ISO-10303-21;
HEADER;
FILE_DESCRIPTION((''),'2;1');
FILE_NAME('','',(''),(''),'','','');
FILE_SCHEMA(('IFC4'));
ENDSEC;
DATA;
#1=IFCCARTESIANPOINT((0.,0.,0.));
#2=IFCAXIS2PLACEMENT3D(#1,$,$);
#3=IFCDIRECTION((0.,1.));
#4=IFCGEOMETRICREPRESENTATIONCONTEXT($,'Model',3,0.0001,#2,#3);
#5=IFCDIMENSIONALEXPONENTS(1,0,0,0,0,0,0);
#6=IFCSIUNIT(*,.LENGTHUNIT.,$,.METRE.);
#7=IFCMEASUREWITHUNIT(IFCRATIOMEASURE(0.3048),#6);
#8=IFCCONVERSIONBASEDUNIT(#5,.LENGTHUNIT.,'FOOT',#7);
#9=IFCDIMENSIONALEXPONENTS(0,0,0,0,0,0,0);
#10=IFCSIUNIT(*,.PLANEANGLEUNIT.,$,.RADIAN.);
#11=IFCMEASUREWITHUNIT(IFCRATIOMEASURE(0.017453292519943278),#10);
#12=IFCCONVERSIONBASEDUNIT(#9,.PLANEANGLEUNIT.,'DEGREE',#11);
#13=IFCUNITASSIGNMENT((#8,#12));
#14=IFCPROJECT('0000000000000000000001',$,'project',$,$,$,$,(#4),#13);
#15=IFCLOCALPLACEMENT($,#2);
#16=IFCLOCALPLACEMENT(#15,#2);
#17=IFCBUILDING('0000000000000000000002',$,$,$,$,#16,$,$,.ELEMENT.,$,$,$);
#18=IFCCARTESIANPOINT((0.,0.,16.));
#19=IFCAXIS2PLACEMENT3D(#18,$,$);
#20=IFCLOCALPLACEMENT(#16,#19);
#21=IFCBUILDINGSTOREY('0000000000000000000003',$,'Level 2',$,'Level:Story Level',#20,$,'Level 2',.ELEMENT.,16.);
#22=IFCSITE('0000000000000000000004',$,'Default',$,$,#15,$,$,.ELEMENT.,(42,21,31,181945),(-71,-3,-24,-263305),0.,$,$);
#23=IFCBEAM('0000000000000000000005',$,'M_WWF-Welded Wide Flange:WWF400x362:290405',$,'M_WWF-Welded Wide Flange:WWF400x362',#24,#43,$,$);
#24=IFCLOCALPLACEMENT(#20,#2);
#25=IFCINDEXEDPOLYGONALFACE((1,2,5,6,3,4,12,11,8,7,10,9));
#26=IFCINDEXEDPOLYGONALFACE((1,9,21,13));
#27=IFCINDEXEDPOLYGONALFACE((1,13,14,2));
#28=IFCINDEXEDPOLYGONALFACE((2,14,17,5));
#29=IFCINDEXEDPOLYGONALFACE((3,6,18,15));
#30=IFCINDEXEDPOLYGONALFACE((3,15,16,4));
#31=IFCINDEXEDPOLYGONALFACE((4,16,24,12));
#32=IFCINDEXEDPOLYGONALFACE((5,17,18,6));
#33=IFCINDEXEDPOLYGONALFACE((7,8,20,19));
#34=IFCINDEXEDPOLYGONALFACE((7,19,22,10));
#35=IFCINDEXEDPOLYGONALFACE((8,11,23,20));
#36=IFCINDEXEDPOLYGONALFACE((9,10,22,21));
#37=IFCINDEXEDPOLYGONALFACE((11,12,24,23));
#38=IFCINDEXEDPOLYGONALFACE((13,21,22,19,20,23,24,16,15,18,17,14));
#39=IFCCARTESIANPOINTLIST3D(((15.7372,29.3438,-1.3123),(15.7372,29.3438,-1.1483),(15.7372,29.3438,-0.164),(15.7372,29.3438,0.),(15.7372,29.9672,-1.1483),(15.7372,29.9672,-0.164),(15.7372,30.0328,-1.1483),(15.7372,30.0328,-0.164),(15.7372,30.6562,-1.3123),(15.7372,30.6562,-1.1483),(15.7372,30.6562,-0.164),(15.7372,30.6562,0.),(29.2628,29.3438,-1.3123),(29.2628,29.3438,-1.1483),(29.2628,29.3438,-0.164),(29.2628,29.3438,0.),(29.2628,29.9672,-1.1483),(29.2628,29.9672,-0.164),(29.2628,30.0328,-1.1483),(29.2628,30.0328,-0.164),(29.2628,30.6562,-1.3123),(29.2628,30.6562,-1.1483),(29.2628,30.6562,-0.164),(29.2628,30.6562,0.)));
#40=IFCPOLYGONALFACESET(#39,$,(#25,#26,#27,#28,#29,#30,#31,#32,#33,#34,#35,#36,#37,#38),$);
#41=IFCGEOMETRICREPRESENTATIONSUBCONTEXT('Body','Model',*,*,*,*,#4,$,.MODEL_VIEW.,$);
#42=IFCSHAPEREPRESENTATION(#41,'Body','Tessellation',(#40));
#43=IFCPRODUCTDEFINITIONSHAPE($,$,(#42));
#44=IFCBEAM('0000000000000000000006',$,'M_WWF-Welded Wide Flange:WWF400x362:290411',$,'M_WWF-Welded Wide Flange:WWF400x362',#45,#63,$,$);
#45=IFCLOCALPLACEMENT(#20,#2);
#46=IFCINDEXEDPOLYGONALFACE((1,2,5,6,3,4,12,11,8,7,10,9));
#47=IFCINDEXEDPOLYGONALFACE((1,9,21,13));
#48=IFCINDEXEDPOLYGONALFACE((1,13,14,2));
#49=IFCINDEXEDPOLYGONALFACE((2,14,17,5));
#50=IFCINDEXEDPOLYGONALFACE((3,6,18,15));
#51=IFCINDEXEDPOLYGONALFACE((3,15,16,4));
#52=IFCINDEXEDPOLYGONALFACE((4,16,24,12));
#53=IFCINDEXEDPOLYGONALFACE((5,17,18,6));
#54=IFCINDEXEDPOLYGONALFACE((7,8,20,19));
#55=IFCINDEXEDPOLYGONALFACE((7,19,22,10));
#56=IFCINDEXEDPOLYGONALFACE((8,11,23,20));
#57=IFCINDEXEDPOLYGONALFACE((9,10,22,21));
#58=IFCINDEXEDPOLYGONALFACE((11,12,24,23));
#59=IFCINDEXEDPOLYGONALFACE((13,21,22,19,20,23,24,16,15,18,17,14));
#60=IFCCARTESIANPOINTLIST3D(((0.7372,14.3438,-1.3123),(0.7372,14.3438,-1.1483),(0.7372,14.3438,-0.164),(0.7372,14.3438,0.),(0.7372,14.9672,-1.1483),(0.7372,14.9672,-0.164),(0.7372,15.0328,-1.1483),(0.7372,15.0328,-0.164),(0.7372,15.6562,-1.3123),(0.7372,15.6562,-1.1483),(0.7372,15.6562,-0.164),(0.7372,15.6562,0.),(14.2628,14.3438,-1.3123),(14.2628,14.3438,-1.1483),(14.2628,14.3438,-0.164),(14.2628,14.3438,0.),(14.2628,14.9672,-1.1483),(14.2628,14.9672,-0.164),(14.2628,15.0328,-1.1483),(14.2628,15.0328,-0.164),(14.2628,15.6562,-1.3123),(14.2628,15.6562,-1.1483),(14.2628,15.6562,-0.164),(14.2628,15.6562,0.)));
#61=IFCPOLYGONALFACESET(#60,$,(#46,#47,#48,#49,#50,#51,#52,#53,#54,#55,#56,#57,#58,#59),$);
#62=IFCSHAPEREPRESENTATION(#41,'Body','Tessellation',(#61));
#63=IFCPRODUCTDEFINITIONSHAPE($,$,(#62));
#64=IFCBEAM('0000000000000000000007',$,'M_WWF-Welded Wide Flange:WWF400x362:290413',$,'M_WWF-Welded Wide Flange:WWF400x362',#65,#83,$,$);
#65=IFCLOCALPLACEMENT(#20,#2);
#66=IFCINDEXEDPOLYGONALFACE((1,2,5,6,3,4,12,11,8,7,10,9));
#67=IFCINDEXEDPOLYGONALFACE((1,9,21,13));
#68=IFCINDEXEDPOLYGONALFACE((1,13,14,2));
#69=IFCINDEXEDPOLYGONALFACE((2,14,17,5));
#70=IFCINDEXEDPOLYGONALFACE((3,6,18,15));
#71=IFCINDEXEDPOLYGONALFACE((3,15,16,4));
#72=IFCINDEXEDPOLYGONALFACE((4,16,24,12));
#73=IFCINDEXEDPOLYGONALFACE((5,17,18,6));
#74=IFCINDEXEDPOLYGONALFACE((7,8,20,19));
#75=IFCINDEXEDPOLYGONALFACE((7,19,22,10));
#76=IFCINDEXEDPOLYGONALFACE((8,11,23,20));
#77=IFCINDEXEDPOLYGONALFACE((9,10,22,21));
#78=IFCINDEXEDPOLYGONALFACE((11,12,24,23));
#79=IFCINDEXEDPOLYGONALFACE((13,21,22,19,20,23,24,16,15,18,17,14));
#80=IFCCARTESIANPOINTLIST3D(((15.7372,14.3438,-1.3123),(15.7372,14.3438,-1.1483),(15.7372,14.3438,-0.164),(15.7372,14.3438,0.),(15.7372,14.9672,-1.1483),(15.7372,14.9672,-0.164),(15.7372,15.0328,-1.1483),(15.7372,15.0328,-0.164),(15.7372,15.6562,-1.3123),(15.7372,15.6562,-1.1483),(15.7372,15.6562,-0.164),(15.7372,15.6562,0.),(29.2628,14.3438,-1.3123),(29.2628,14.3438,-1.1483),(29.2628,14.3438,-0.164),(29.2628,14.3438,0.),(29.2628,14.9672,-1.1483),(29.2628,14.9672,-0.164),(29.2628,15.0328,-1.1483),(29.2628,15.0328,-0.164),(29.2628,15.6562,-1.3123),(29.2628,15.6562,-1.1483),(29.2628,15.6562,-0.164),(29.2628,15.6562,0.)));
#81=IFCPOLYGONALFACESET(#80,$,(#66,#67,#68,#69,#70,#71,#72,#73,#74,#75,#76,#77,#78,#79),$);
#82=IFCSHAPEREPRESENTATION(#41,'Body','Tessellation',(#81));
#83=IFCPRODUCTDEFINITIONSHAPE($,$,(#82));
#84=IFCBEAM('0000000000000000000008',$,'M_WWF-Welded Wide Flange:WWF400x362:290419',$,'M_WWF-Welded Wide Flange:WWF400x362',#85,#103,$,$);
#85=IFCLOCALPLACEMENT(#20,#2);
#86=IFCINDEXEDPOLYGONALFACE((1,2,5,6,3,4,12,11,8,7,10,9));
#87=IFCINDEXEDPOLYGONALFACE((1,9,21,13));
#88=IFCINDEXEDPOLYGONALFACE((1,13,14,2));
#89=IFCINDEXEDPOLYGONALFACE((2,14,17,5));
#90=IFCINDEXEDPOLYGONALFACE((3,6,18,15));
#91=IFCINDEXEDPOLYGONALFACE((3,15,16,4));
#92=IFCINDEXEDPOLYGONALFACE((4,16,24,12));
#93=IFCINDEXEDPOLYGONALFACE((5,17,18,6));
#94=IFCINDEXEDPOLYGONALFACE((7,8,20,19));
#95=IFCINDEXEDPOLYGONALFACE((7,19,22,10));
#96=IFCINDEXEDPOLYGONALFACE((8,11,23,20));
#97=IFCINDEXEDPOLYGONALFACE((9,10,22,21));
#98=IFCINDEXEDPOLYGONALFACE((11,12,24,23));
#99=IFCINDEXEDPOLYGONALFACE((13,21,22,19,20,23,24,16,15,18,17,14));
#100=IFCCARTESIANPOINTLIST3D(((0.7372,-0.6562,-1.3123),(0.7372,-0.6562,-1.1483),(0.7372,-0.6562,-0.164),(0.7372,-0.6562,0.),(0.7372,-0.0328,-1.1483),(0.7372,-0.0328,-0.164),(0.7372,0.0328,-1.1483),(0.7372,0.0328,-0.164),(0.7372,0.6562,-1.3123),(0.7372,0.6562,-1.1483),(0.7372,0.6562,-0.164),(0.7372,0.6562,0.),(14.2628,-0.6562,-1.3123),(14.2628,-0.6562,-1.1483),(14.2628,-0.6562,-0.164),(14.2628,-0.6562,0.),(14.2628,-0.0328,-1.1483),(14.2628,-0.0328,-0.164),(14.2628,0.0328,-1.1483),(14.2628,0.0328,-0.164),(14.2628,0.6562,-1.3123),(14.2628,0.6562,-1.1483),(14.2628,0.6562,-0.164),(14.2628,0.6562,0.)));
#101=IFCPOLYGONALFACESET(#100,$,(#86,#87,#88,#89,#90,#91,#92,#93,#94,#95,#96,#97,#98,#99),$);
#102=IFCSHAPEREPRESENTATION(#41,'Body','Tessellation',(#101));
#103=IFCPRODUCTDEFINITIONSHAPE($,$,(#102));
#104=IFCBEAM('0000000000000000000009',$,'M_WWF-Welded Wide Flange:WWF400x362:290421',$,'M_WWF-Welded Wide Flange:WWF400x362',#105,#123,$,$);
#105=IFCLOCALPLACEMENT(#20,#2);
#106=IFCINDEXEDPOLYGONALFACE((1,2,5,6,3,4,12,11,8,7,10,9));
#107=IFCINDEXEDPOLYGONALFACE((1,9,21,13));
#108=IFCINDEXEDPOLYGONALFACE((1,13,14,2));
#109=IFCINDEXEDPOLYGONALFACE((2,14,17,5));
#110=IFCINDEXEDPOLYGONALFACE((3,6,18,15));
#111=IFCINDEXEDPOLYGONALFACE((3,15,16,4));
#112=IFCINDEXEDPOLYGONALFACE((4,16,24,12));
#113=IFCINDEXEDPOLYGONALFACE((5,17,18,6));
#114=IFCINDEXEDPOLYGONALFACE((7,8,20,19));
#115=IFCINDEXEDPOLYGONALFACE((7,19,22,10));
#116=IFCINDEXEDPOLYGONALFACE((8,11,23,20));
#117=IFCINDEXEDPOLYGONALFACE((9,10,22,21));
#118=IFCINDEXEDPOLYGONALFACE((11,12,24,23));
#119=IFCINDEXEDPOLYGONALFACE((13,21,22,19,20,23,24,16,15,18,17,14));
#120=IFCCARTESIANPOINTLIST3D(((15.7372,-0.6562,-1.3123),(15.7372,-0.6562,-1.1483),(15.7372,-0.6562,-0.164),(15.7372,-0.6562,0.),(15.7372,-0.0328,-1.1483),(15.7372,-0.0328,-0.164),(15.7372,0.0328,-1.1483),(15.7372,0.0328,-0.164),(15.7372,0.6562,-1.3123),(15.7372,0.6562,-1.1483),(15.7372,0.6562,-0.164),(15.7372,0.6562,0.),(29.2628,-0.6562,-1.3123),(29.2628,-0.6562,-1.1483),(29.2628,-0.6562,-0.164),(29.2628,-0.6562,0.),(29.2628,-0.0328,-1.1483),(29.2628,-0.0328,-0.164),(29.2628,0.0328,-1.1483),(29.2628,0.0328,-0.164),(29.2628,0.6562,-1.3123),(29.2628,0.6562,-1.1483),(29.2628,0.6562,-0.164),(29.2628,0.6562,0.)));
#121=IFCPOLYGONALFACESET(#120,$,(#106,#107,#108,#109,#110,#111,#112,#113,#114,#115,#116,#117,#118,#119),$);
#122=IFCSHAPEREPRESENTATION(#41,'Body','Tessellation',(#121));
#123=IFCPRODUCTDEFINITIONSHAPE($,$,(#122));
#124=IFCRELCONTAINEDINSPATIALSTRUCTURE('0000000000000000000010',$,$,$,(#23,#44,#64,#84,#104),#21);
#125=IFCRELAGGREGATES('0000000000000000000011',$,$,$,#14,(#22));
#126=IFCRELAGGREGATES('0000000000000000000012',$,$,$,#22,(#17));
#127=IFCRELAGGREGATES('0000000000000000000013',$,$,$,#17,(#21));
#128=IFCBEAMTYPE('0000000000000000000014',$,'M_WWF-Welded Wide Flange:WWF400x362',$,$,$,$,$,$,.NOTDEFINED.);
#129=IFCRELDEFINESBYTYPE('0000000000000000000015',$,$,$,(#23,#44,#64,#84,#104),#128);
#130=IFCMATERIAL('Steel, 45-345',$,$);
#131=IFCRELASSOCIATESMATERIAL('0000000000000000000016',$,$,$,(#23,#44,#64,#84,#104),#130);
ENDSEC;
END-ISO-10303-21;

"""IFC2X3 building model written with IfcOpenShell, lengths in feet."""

from ifc_helpers import new_model, entity, si_unit, converted_unit, direction, frame, frame_2d, origin, place, context, subcontext, project, spatial, i_section, extrude, material, type_object, element, save


model = new_model("IFC2X3")

# Units and contexts
model_context = context("Model", 3, precision=0.0001, world=origin(), true_north=direction((0.0, 1.0)))
body_context = subcontext(model_context, "Body", "Model", "MODEL_VIEW")
ifc_project = project(units=[converted_unit("LENGTHUNIT", "FOOT", entity("IfcRatioMeasure", 0.3048), si_unit("LENGTHUNIT", "METRE"), dimensions=[1, 0, 0, 0, 0, 0, 0]), converted_unit("PLANEANGLEUNIT", "DEGREE", entity("IfcRatioMeasure", 0.017453292519943278), si_unit("PLANEANGLEUNIT", "RADIAN"), dimensions=[0, 0, 0, 0, 0, 0, 0])], contexts=[model_context])

# Site, building, storey
site_placement = place(None, origin())
site = spatial("IfcSite", under=ifc_project, at=site_placement, Name="Default", CompositionType="ELEMENT", RefLatitude=(42, 21, 31, 181945), RefLongitude=(-71, -3, -24, -263305), RefElevation=0.0)
building_placement = place(site_placement, origin())
building = spatial("IfcBuilding", under=site, at=building_placement, CompositionType="ELEMENT")
storey_placement = place(building_placement, frame((0.0, 0.0, 16.0)))
storey = spatial("IfcBuildingStorey", under=building, at=storey_placement, Name="Level 2", ObjectType="Level:Story Level", LongName="Level 2", CompositionType="ELEMENT", Elevation=16.0)

# Shared definitions
ifc_material = material(Name="Steel, 45-345")

# Beams
beam_type = type_object("IfcBeamType", Name="M_WWF-Welded Wide Flange:WWF400x362", PredefinedType="NOTDEFINED")
beam_1_placement = place(storey_placement, frame((15.0, 30.0, 0.0)))
element("IfcBeam", 1, at=beam_1_placement, inside=storey, type_object=beam_type, material=ifc_material, Name="M_WWF-Welded Wide Flange:WWF400x362:290405", ObjectType="M_WWF-Welded Wide Flange:WWF400x362", context=body_context, shape_type="SweptSolid", body=[
    extrude(i_section(OverallWidth=1.3123, OverallDepth=1.3123, WebThickness=0.0656, FlangeThickness=0.164, at=frame_2d((0.0, 0.0), x_axis=(0.0, 1.0))), frame((0.7372, 0.0, -0.6562), z_axis=(1.0, 0.0, 0.0), x_axis=(0.0, 0.0, -1.0)), (0.0, 0.0, 1.0), 13.5256),
])
beam_2_placement = place(storey_placement, frame((0.0, 15.0, 0.0)))
element("IfcBeam", 2, at=beam_2_placement, inside=storey, type_object=beam_type, material=ifc_material, Name="M_WWF-Welded Wide Flange:WWF400x362:290411", ObjectType="M_WWF-Welded Wide Flange:WWF400x362", context=body_context, shape_type="SweptSolid", body=[
    extrude(i_section(OverallWidth=1.3123, OverallDepth=1.3123, WebThickness=0.0656, FlangeThickness=0.164, at=frame_2d((0.0, 0.0), x_axis=(0.0, 1.0))), frame((0.7372, 0.0, -0.6562), z_axis=(1.0, 0.0, 0.0), x_axis=(0.0, 0.0, -1.0)), (0.0, 0.0, 1.0), 13.5256),
])
beam_3_placement = place(storey_placement, frame((15.0, 15.0, 0.0)))
element("IfcBeam", 3, at=beam_3_placement, inside=storey, type_object=beam_type, material=ifc_material, Name="M_WWF-Welded Wide Flange:WWF400x362:290413", ObjectType="M_WWF-Welded Wide Flange:WWF400x362", context=body_context, shape_type="SweptSolid", body=[
    extrude(i_section(OverallWidth=1.3123, OverallDepth=1.3123, WebThickness=0.0656, FlangeThickness=0.164, at=frame_2d((0.0, 0.0), x_axis=(0.0, 1.0))), frame((0.7372, 0.0, -0.6562), z_axis=(1.0, 0.0, 0.0), x_axis=(0.0, 0.0, -1.0)), (0.0, 0.0, 1.0), 13.5256),
])
beam_4_placement = place(storey_placement, origin())
element("IfcBeam", 4, at=beam_4_placement, inside=storey, type_object=beam_type, material=ifc_material, Name="M_WWF-Welded Wide Flange:WWF400x362:290419", ObjectType="M_WWF-Welded Wide Flange:WWF400x362", context=body_context, shape_type="SweptSolid", body=[
    extrude(i_section(OverallWidth=1.3123, OverallDepth=1.3123, WebThickness=0.0656, FlangeThickness=0.164, at=frame_2d((0.0, 0.0), x_axis=(0.0, 1.0))), frame((0.7372, 0.0, -0.6562), z_axis=(1.0, 0.0, 0.0), x_axis=(0.0, 0.0, -1.0)), (0.0, 0.0, 1.0), 13.5256),
])
beam_5_placement = place(storey_placement, frame((15.0, 0.0, 0.0)))
element("IfcBeam", 5, at=beam_5_placement, inside=storey, type_object=beam_type, material=ifc_material, Name="M_WWF-Welded Wide Flange:WWF400x362:290421", ObjectType="M_WWF-Welded Wide Flange:WWF400x362", context=body_context, shape_type="SweptSolid", body=[
    extrude(i_section(OverallWidth=1.3123, OverallDepth=1.3123, WebThickness=0.0656, FlangeThickness=0.164, at=frame_2d((0.0, 0.0), x_axis=(0.0, 1.0))), frame((0.7372, 0.0, -0.6562), z_axis=(1.0, 0.0, 0.0), x_axis=(0.0, 0.0, -1.0)), (0.0, 0.0, 1.0), 13.5256),
])

save(model, "model.ifc")
